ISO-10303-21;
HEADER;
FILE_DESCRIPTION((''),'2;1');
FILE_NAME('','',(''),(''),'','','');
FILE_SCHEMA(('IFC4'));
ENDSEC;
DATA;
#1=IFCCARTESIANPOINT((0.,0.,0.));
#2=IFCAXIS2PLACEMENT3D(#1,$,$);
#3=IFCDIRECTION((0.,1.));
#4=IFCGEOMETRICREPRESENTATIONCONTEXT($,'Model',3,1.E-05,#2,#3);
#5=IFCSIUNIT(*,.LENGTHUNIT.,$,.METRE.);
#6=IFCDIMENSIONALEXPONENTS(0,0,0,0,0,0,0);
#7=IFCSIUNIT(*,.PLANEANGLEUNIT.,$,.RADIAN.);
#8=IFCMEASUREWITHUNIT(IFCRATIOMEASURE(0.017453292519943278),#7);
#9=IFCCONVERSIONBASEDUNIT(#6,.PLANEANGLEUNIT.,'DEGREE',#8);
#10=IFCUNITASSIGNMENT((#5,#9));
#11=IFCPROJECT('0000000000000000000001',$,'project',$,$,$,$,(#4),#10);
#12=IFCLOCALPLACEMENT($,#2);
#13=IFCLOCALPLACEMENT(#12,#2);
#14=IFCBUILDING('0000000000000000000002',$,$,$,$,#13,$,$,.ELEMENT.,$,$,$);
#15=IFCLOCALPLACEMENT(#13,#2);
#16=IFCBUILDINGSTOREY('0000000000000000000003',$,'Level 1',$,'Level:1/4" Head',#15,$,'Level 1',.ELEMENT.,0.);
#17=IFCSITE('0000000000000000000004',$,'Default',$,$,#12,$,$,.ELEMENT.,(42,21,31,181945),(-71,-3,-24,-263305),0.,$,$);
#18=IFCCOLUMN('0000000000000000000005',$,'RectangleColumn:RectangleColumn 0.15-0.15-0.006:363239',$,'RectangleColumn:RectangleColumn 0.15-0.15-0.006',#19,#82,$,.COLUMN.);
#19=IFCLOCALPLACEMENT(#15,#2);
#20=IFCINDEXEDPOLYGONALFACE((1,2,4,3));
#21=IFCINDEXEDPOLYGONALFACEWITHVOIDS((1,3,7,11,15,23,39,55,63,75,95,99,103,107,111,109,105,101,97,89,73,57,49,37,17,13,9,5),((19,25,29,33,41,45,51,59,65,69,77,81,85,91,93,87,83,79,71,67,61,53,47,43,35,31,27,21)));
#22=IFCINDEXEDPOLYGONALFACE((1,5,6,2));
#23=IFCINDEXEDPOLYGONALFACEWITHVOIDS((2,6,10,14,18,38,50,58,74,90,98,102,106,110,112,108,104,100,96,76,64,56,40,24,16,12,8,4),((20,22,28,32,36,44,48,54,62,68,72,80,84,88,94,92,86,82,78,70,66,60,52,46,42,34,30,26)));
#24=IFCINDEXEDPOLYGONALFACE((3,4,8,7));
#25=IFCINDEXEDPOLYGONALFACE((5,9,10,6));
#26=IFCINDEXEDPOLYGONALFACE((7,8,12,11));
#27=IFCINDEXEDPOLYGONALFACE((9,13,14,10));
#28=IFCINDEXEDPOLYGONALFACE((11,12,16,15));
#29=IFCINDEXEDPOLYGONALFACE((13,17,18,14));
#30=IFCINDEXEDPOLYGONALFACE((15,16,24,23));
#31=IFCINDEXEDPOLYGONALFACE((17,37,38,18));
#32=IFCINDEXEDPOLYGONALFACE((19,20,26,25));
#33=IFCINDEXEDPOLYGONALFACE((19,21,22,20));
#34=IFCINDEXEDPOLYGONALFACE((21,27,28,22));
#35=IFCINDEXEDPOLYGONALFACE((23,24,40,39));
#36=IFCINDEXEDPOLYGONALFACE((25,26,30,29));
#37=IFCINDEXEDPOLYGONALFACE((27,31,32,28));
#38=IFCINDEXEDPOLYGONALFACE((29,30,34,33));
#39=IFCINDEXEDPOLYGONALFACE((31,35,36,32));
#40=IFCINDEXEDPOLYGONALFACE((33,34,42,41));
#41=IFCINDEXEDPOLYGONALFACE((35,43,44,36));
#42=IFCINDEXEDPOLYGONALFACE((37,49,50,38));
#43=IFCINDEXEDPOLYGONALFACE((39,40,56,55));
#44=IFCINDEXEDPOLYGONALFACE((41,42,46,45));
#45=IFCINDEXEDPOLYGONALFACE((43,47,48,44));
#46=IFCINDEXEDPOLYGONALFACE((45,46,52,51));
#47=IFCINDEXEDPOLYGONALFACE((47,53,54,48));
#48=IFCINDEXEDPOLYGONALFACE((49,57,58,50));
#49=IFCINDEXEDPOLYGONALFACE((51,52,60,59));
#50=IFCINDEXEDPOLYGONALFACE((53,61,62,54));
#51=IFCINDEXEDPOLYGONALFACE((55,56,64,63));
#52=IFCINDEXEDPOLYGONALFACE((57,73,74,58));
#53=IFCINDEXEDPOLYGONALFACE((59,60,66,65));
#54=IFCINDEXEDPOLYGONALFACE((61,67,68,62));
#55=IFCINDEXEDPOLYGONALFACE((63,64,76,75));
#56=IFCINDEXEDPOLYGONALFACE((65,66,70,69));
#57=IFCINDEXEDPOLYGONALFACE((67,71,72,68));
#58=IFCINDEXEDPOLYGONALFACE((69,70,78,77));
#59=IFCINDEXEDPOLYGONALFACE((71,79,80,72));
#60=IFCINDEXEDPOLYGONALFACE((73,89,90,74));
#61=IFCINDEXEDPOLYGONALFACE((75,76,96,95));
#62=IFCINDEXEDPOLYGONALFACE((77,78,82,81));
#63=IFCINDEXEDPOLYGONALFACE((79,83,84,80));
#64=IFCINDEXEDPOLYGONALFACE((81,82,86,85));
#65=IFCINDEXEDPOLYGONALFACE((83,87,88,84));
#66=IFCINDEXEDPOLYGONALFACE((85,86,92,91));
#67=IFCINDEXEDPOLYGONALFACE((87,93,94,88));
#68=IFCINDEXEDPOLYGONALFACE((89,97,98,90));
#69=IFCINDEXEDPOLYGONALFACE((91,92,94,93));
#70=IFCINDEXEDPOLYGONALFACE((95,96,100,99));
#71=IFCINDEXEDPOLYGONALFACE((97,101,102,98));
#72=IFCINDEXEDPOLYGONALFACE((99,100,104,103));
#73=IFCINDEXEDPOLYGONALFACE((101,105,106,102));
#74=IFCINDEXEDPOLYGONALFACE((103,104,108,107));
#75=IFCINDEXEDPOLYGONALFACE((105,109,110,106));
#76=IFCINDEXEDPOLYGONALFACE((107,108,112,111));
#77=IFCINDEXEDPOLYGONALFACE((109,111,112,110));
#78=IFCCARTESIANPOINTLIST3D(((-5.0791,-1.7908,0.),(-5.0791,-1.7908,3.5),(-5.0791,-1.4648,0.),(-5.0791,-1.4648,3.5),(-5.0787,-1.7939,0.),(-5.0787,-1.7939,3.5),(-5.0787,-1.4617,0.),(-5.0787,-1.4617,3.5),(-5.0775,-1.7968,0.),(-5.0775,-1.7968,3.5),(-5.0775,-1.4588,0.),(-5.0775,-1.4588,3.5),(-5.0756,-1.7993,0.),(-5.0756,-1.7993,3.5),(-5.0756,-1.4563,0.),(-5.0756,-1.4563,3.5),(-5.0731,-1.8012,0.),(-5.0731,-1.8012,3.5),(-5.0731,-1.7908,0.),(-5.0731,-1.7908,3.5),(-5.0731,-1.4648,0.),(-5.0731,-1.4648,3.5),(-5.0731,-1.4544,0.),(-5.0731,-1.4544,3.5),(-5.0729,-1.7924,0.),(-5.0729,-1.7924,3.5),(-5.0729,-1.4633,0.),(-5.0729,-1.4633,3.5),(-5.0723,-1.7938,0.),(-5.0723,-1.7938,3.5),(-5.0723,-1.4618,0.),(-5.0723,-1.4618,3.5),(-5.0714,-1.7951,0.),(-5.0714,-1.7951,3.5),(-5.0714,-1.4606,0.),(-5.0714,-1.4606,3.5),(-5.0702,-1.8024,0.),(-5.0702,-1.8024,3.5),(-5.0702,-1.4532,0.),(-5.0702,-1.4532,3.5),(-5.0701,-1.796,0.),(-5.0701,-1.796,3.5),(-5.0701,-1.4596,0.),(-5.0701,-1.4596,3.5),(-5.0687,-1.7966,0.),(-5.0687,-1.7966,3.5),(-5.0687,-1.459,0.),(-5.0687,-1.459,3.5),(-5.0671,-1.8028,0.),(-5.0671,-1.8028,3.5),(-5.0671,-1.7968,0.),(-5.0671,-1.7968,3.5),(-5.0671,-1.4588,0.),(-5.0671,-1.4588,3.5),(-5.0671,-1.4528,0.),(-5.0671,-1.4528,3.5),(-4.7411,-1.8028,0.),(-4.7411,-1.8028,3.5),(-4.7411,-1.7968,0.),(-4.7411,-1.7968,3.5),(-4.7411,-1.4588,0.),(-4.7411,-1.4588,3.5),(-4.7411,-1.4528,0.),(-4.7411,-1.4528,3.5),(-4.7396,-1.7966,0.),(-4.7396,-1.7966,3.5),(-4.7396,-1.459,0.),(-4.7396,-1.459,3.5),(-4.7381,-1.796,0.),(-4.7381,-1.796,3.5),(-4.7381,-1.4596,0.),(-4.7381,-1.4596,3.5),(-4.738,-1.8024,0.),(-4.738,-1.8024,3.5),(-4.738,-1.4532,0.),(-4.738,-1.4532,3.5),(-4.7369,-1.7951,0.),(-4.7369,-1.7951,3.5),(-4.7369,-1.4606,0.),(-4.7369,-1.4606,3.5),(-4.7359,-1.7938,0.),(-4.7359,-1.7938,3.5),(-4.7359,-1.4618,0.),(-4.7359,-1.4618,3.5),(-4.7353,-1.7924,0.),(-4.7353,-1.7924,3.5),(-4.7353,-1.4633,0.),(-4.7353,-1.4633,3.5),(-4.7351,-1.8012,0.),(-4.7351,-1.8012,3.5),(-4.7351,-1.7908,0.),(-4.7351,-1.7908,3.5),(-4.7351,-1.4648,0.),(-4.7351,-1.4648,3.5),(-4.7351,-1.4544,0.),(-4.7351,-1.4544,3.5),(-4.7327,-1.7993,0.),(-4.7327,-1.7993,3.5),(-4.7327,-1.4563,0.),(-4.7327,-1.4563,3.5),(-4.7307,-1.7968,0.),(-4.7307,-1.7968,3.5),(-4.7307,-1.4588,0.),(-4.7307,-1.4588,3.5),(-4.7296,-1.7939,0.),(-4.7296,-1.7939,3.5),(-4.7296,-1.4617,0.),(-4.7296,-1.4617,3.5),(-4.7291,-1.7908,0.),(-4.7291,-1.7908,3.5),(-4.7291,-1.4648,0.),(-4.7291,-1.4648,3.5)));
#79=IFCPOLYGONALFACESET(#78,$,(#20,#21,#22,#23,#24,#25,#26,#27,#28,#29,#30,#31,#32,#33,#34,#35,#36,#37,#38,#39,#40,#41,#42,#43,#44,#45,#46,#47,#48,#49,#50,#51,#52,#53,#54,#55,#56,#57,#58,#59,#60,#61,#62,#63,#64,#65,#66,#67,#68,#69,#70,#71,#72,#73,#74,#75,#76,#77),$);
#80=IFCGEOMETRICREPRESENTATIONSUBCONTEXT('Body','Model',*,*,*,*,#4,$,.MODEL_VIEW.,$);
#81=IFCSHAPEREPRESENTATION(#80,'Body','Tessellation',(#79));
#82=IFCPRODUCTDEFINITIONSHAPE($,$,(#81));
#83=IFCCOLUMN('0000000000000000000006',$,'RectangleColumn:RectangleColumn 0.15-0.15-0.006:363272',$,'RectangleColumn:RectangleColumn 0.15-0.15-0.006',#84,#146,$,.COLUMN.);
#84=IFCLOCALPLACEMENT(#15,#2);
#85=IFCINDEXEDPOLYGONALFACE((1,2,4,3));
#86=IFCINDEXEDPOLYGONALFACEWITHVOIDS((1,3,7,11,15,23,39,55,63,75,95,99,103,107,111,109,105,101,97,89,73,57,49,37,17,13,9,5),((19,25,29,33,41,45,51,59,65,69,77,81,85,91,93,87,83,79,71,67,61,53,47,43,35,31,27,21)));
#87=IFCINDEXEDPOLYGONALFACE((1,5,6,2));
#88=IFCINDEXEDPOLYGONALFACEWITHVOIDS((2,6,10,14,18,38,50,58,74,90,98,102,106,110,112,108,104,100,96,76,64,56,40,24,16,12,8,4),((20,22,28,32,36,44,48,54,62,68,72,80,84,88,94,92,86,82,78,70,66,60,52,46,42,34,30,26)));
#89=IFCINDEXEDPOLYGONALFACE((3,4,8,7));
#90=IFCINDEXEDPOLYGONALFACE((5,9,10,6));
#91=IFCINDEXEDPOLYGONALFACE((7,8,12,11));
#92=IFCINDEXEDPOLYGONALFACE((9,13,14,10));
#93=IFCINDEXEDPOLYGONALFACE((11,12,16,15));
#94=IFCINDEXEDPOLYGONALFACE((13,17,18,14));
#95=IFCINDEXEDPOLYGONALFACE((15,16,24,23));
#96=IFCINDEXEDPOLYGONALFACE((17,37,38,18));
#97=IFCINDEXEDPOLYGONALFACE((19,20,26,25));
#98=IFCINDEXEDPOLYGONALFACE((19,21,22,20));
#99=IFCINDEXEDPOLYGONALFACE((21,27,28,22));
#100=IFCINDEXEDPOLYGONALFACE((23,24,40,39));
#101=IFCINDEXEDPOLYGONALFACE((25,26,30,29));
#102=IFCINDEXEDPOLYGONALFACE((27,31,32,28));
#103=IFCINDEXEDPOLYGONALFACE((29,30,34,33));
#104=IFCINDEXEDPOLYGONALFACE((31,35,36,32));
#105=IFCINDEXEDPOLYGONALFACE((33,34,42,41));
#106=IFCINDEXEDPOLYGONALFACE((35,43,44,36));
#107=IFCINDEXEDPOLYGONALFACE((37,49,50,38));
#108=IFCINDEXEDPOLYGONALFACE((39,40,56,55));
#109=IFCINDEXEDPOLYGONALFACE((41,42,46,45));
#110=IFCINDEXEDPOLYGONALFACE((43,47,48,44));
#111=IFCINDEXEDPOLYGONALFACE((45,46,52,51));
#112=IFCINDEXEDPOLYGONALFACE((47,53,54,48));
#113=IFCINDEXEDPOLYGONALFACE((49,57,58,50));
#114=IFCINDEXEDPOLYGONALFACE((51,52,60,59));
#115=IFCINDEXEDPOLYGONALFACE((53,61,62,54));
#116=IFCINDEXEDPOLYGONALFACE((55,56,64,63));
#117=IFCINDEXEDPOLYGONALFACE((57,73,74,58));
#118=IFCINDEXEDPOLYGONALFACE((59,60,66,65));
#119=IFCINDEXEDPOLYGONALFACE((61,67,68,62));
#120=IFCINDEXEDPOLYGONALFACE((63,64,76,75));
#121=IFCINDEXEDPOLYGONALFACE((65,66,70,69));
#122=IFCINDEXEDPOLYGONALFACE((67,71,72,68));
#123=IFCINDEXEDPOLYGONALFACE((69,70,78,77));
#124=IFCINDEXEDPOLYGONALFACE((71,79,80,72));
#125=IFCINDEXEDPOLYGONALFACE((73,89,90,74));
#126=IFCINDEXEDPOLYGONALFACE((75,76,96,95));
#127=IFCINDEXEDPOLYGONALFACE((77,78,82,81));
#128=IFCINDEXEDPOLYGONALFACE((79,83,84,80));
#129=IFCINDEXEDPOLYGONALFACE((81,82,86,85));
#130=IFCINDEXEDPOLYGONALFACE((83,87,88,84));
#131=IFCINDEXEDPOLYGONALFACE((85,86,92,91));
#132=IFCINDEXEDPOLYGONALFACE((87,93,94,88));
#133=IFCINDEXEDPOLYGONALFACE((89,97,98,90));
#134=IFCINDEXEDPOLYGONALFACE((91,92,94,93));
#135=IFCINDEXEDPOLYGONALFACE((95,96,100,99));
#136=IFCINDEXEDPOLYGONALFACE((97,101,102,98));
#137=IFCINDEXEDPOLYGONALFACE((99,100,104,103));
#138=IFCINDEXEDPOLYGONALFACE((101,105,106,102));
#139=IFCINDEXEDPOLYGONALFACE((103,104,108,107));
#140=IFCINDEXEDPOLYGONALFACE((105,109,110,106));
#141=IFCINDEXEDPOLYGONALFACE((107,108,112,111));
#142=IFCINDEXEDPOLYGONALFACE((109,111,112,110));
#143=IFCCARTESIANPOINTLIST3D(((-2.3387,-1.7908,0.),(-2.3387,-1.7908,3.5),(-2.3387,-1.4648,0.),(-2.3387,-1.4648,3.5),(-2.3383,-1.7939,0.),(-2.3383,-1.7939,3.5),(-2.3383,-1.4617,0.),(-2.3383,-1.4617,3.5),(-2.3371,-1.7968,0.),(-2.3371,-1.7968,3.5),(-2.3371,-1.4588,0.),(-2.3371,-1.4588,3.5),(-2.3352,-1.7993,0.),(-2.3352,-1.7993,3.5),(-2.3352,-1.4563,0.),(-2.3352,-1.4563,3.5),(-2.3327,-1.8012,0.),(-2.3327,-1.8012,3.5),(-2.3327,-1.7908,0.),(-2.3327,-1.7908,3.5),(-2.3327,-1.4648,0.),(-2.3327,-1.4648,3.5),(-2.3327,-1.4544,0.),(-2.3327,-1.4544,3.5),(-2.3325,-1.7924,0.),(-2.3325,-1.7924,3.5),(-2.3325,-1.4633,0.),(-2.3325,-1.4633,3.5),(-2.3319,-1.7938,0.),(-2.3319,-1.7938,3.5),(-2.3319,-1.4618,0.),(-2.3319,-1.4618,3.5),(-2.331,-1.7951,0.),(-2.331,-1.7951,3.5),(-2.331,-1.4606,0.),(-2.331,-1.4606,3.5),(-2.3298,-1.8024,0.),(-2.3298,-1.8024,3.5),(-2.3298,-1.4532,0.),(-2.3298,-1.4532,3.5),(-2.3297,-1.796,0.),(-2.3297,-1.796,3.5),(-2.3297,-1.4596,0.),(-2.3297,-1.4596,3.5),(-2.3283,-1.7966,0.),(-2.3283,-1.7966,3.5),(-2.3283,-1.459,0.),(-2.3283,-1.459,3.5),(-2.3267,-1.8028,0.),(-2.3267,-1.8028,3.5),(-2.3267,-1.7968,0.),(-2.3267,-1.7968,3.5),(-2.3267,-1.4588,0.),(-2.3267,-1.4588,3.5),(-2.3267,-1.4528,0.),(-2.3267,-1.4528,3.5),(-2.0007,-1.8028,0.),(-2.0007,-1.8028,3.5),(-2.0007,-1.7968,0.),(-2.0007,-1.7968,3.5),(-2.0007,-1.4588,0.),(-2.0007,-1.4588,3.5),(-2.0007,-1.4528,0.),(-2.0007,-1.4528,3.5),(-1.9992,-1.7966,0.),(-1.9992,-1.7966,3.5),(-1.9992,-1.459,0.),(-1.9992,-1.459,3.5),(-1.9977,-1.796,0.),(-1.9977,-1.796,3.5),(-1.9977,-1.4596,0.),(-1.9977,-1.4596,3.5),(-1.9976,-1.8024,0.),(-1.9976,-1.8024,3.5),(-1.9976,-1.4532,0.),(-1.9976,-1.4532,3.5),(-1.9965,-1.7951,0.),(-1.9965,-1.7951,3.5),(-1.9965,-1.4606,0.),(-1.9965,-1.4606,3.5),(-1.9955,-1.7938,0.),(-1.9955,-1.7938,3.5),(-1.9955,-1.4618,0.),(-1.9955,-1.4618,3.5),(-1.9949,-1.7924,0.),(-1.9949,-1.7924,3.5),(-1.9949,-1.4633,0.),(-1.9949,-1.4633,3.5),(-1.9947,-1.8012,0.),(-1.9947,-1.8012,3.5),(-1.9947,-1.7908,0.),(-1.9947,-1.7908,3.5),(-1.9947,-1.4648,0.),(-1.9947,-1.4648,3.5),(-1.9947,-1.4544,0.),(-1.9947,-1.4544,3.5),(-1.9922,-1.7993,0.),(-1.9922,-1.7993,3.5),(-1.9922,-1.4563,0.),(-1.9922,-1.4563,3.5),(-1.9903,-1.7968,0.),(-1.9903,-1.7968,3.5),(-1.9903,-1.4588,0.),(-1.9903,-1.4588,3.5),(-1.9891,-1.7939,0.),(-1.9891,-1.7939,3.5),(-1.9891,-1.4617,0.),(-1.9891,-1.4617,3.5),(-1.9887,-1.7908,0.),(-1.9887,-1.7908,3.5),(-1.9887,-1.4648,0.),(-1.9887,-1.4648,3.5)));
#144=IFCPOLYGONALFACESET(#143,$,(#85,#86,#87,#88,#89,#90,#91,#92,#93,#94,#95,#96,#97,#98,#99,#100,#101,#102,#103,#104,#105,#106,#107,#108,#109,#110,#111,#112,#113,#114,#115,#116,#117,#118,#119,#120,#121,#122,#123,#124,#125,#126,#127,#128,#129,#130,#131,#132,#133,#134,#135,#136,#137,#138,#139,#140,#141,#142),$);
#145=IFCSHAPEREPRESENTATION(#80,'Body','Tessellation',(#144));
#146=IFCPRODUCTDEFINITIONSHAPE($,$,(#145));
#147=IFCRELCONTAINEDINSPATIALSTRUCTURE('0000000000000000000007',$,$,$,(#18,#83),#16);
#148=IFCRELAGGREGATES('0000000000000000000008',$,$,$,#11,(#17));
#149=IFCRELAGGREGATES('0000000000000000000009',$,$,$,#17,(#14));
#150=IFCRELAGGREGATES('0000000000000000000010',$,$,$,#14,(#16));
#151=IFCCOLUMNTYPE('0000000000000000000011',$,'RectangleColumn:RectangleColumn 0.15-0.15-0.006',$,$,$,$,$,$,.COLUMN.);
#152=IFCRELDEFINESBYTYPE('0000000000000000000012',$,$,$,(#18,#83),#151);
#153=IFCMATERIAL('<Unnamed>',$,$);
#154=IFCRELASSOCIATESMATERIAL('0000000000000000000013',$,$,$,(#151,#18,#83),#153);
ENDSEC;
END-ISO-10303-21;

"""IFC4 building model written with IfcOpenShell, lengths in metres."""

from ifc_helpers import new_model, entity, si_unit, converted_unit, direction, frame, origin, place, context, subcontext, project, spatial, line, arc, indexed_curve, outline, extrude, source, transform, mapped, material, type_object, type_shapes, element, save


model = new_model("IFC4")

# Units and contexts
model_context = context("Model", 3, precision=1e-05, world=origin(), true_north=direction((0.0, 1.0)))
body_context = subcontext(model_context, "Body", "Model", "MODEL_VIEW")
ifc_project = project(units=[si_unit("LENGTHUNIT", "METRE"), converted_unit("PLANEANGLEUNIT", "DEGREE", entity("IfcRatioMeasure", 0.017453292519943278), si_unit("PLANEANGLEUNIT", "RADIAN"), dimensions=[0, 0, 0, 0, 0, 0, 0])], contexts=[model_context])

# Site, building, storey
site_placement = place(None, origin())
site = spatial("IfcSite", under=ifc_project, at=site_placement, Name="Default", CompositionType="ELEMENT", RefLatitude=(42, 21, 31, 181945), RefLongitude=(-71, -3, -24, -263305), RefElevation=0.0)
building_placement = place(site_placement, origin())
building = spatial("IfcBuilding", under=site, at=building_placement, CompositionType="ELEMENT")
storey_placement = place(building_placement, origin())
storey = spatial("IfcBuildingStorey", under=building, at=storey_placement, Name="Level 1", ObjectType="Level:1/4\" Head", LongName="Level 1", CompositionType="ELEMENT", Elevation=0.0)

# Columns
ifc_material_1 = material(Name="<Unnamed>")
column_type = type_object("IfcColumnType", Name="RectangleColumn:RectangleColumn 0.15-0.15-0.006", PredefinedType="COLUMN", material=ifc_material_1)
shared_shape = source(origin(), body_context, "Body", "SweptSolid", [
    extrude(outline(indexed_curve([(-0.163, -0.175), (0.163, -0.175), (0.1715, -0.1715), (0.175, -0.163), (0.175, 0.163), (0.1715, 0.1715), (0.163, 0.175), (-0.163, 0.175), (-0.1715, 0.1715), (-0.175, 0.163), (-0.175, -0.163), (-0.1715, -0.1715)], segments=[line(1, 2), arc(2, 3, 4), line(4, 5), arc(5, 6, 7), line(7, 8), arc(8, 9, 10), line(10, 11), arc(11, 12, 1)], self_intersect=False), holes=[indexed_curve([(-0.163, -0.169), (-0.1672, -0.1672), (-0.169, -0.163), (-0.169, 0.163), (-0.1672, 0.1672), (-0.163, 0.169), (0.163, 0.169), (0.1672, 0.1672), (0.169, 0.163), (0.169, -0.163), (0.1672, -0.1672), (0.163, -0.169)], segments=[arc(1, 2, 3), line(3, 4), arc(4, 5, 6), line(6, 7), arc(7, 8, 9), line(9, 10), arc(10, 11, 12), line(12, 1)], self_intersect=False)]), frame((0.0, 0.0, 0.0), z_axis=(0.0, 0.0, 1.0), x_axis=(-1.0, 0.0, 0.0)), (0.0, 0.0, 1.0), 3.5),
])
type_shapes(column_type, [shared_shape])
for number, where, name in (
    (1, (-4.9041, -1.6278, 0.0), "RectangleColumn:RectangleColumn 0.15-0.15-0.006:363239"),
    (2, (-2.1637, -1.6278, 0.0), "RectangleColumn:RectangleColumn 0.15-0.15-0.006:363272"),
):
    element("IfcColumn", number, at=place(storey_placement, frame(where)), inside=storey, type_object=column_type, material=ifc_material_1, Name=name, ObjectType="RectangleColumn:RectangleColumn 0.15-0.15-0.006", PredefinedType="COLUMN", context=body_context, shape_type="MappedRepresentation", body=[
        mapped(shared_shape, transform((0.0, 0.0, 0.0), scale=1.0)),
    ])

save(model, "model.ifc")
